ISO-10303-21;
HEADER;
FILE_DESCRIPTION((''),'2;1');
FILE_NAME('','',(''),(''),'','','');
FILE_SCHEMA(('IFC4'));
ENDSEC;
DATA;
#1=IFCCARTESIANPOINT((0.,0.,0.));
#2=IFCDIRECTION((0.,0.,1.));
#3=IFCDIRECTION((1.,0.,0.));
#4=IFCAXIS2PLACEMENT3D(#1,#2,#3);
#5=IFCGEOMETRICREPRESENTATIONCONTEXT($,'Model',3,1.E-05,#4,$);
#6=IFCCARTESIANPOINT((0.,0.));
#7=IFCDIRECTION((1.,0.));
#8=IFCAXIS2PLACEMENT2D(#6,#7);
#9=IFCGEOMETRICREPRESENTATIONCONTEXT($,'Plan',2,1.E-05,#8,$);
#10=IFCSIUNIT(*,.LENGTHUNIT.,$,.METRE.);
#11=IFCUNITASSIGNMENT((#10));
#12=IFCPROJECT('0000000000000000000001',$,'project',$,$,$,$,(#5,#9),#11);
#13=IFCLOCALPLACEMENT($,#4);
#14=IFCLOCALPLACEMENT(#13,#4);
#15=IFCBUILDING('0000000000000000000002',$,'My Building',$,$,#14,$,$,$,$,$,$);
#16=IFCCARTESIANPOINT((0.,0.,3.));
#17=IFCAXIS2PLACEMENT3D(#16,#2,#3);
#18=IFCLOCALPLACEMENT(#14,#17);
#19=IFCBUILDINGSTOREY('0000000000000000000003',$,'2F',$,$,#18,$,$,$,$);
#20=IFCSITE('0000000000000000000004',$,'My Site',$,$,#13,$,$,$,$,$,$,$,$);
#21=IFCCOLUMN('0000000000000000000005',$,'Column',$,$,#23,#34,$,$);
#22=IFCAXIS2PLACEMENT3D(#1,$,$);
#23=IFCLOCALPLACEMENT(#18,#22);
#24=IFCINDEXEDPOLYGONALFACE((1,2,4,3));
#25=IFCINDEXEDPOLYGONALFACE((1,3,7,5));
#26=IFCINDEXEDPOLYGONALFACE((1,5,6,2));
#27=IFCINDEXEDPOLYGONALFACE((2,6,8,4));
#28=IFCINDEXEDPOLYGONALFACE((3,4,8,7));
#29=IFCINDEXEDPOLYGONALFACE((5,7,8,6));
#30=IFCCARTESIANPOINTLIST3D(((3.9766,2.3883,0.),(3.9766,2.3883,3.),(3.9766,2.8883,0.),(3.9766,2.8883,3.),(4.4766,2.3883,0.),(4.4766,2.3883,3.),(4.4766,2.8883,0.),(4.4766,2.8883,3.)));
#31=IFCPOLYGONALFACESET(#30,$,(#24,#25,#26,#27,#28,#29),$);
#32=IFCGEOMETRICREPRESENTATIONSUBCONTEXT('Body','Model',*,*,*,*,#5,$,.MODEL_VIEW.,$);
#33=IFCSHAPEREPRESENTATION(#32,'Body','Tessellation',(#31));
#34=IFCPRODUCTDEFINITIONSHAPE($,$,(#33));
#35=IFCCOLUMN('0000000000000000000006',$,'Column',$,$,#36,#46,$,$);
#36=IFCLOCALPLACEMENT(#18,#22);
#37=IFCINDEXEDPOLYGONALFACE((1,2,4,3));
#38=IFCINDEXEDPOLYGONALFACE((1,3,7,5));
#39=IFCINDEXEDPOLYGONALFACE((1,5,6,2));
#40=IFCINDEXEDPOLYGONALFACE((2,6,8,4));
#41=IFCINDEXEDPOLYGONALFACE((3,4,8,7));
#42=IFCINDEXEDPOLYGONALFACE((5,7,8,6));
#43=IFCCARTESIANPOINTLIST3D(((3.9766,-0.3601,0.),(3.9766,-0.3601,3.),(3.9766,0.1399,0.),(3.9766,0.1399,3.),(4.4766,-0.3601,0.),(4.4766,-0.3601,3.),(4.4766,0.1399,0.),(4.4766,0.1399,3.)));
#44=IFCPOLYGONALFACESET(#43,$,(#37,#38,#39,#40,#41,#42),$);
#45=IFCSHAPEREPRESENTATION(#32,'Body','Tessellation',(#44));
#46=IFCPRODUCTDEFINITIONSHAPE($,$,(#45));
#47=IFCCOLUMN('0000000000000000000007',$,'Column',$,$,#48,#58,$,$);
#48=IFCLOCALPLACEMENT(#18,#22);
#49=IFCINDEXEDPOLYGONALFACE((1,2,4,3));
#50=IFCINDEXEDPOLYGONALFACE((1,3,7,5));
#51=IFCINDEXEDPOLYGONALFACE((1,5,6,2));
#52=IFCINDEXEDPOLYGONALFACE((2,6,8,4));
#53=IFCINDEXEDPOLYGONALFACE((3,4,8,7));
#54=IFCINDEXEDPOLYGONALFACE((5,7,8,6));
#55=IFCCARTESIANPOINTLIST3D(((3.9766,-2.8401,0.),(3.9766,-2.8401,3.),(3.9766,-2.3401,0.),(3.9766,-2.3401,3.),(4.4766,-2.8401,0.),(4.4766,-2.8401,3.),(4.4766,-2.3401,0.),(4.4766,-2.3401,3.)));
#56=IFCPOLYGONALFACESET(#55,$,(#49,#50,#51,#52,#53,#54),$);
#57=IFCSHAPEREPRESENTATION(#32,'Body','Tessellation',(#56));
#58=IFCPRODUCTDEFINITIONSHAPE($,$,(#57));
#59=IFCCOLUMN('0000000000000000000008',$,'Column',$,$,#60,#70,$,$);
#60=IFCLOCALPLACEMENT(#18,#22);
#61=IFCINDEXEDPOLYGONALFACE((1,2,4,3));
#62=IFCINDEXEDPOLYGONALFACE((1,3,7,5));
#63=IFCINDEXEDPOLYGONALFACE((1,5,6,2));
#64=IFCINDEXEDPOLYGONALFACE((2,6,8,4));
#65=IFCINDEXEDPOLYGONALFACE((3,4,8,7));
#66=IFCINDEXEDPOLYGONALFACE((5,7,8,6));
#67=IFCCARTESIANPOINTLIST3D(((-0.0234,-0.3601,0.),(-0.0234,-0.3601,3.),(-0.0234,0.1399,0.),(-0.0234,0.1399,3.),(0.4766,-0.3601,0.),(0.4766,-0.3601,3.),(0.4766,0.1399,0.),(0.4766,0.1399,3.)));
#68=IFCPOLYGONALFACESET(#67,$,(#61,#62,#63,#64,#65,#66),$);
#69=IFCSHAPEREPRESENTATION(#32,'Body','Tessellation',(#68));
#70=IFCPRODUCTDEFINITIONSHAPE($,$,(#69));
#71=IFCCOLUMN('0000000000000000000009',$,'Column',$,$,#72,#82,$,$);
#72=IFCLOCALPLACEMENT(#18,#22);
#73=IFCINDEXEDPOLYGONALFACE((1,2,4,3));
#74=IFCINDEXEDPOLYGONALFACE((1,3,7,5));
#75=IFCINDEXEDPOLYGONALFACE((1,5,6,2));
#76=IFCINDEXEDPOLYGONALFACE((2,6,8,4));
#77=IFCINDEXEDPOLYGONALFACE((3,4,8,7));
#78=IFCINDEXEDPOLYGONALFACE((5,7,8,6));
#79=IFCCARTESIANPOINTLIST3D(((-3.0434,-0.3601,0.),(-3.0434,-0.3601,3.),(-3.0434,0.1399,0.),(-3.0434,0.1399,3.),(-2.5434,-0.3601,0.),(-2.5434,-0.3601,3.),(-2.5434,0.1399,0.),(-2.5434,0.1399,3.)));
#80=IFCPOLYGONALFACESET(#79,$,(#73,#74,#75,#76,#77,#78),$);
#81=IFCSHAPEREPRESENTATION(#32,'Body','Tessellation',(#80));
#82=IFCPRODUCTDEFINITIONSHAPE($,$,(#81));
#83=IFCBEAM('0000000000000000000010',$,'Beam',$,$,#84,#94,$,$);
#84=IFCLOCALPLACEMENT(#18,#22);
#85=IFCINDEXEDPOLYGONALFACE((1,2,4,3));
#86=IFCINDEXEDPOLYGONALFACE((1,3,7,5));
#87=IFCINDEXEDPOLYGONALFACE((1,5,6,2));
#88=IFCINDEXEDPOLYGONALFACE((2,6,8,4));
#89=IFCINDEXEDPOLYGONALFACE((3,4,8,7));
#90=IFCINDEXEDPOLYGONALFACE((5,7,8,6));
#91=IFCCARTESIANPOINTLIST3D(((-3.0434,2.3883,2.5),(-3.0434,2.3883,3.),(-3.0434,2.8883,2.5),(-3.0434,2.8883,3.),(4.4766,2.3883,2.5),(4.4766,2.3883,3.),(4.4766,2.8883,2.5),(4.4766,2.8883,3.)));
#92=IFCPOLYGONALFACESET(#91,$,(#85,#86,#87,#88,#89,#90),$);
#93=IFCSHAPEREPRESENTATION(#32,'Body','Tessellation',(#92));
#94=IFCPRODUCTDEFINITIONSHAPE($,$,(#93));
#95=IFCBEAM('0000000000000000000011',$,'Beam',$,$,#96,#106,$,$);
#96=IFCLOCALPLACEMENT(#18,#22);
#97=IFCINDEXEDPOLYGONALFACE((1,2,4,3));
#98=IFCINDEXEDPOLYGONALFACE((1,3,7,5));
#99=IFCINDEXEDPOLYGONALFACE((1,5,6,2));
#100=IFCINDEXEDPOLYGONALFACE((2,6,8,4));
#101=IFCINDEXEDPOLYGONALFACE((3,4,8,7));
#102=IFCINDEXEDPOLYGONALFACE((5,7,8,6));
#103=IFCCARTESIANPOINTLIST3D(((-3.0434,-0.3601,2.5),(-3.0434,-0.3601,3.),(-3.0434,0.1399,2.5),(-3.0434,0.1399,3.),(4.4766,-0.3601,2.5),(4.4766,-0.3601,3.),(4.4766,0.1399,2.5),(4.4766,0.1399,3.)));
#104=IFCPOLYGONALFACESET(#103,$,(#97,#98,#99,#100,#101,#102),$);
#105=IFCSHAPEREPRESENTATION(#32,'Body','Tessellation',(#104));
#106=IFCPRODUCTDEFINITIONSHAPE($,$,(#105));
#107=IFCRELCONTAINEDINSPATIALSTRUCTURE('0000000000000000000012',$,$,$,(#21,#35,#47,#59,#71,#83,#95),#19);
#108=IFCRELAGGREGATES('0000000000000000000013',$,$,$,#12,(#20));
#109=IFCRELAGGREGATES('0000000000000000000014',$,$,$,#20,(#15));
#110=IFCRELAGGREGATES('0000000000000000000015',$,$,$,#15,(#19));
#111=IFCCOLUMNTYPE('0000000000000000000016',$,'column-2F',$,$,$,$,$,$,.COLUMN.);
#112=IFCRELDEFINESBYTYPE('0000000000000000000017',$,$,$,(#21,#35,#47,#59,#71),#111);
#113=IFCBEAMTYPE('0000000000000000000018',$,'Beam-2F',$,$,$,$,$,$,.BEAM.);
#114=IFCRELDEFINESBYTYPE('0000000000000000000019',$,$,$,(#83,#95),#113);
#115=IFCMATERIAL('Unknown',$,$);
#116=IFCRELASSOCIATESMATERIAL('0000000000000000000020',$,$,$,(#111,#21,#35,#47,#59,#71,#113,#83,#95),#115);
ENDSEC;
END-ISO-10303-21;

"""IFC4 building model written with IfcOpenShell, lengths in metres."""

from ifc_helpers import new_model, si_unit, frame, origin_with_axes, origin_2d_with_axis, place, context, subcontext, project, spatial, rectangle, extrude, material, material_profile, profile_set, profile_usage, type_object, element, save


model = new_model("IFC4")

# Units and contexts
model_context = context("Model", 3, precision=1e-05, world=origin_with_axes())
plan_context = context("Plan", 2, precision=1e-05, world=origin_2d_with_axis())
body_context_1 = subcontext(model_context, "Body", "Model", "MODEL_VIEW")
ifc_project = project(units=[si_unit("LENGTHUNIT", "METRE")], contexts=[model_context, plan_context])

# Site, building, storey
site_placement = place(None, origin_with_axes())
site = spatial("IfcSite", under=ifc_project, at=site_placement, Name="My Site")
building_placement = place(site_placement, origin_with_axes())
building = spatial("IfcBuilding", under=site, at=building_placement, Name="My Building")
storey_placement = place(building_placement, frame((0.0, 0.0, 3.0), z_axis=(0.0, 0.0, 1.0), x_axis=(1.0, 0.0, 0.0)))
storey = spatial("IfcBuildingStorey", under=building, at=storey_placement, Name="2F")

# Columns
ifc_material = material(Name="Unknown")
ifc_material_profile_1 = material_profile(ifc_material, rectangle(XDim=0.5, YDim=0.5))
ifc_profile_set_1 = profile_set([ifc_material_profile_1])
ifc_profile_usage_1 = profile_usage(ifc_profile_set_1, cardinal=7)
column_type = type_object("IfcColumnType", Name="column-2F", PredefinedType="COLUMN", material=ifc_profile_set_1)
column_1_placement = place(storey_placement, frame((4.4766, 2.8883, 0.0), z_axis=(0.0, 0.0, 1.0), x_axis=(1.0, 0.0, 0.0)))
element("IfcColumn", 1, at=column_1_placement, inside=storey, type_object=column_type, material=ifc_profile_usage_1, Name="Column", context=body_context_1, shape_type="SweptSolid", body=[
    extrude(rectangle(XDim=0.5, YDim=0.5), frame((-0.25, -0.25, 0.0), z_axis=(0.0, 0.0, 1.0), x_axis=(1.0, 0.0, 0.0)), (0.0, 0.0, 1.0), 3.0),
])
ifc_profile_usage_2 = profile_usage(ifc_profile_set_1, cardinal=7)
column_2_placement = place(storey_placement, frame((4.4766, 0.1399, 0.0), z_axis=(0.0, 0.0, 1.0), x_axis=(1.0, 0.0, 0.0)))
element("IfcColumn", 2, at=column_2_placement, inside=storey, type_object=column_type, material=ifc_profile_usage_2, Name="Column", context=body_context_1, shape_type="SweptSolid", body=[
    extrude(rectangle(XDim=0.5, YDim=0.5), frame((-0.25, -0.25, 0.0), z_axis=(0.0, 0.0, 1.0), x_axis=(1.0, 0.0, 0.0)), (0.0, 0.0, 1.0), 3.0),
])
ifc_profile_usage_3 = profile_usage(ifc_profile_set_1, cardinal=7)
column_3_placement = place(storey_placement, frame((4.4766, -2.3401, 0.0), z_axis=(0.0, 0.0, 1.0), x_axis=(1.0, 0.0, 0.0)))
element("IfcColumn", 3, at=column_3_placement, inside=storey, type_object=column_type, material=ifc_profile_usage_3, Name="Column", context=body_context_1, shape_type="SweptSolid", body=[
    extrude(rectangle(XDim=0.5, YDim=0.5), frame((-0.25, -0.25, 0.0), z_axis=(0.0, 0.0, 1.0), x_axis=(1.0, 0.0, 0.0)), (0.0, 0.0, 1.0), 3.0),
])
ifc_profile_usage_4 = profile_usage(ifc_profile_set_1, cardinal=7)
column_4_placement = place(storey_placement, frame((0.4766, 0.1399, 0.0), z_axis=(0.0, 0.0, 1.0), x_axis=(1.0, 0.0, 0.0)))
element("IfcColumn", 4, at=column_4_placement, inside=storey, type_object=column_type, material=ifc_profile_usage_4, Name="Column", context=body_context_1, shape_type="SweptSolid", body=[
    extrude(rectangle(XDim=0.5, YDim=0.5), frame((-0.25, -0.25, 0.0), z_axis=(0.0, 0.0, 1.0), x_axis=(1.0, 0.0, 0.0)), (0.0, 0.0, 1.0), 3.0),
])
ifc_profile_usage_5 = profile_usage(ifc_profile_set_1, cardinal=7)
column_5_placement = place(storey_placement, frame((-2.5434, 0.1399, 0.0), z_axis=(0.0, 0.0, 1.0), x_axis=(1.0, 0.0, 0.0)))
element("IfcColumn", 5, at=column_5_placement, inside=storey, type_object=column_type, material=ifc_profile_usage_5, Name="Column", context=body_context_1, shape_type="SweptSolid", body=[
    extrude(rectangle(XDim=0.5, YDim=0.5), frame((-0.25, -0.25, 0.0), z_axis=(0.0, 0.0, 1.0), x_axis=(1.0, 0.0, 0.0)), (0.0, 0.0, 1.0), 3.0),
])

# Beams
ifc_material_profile_2 = material_profile(ifc_material, rectangle(XDim=0.5, YDim=0.5))
ifc_profile_set_2 = profile_set([ifc_material_profile_2])
ifc_profile_usage_6 = profile_usage(ifc_profile_set_2, cardinal=7)
beam_type = type_object("IfcBeamType", Name="Beam-2F", PredefinedType="BEAM", material=ifc_profile_set_2)
beam_1_placement = place(storey_placement, frame((4.4766, 2.3883, 3.0), z_axis=(-1.0, 0.0, 0.0), x_axis=(0.0, -1.0, 0.0)))
element("IfcBeam", 6, at=beam_1_placement, inside=storey, type_object=beam_type, material=ifc_profile_usage_6, Name="Beam", context=body_context_1, shape_type="SweptSolid", body=[
    extrude(rectangle(XDim=0.5, YDim=0.5), frame((-0.25, -0.25, 0.0), z_axis=(0.0, 0.0, 1.0), x_axis=(1.0, 0.0, 0.0)), (0.0, 0.0, 1.0), 7.52),
])
ifc_profile_usage_7 = profile_usage(ifc_profile_set_2, cardinal=7)
beam_2_placement = place(storey_placement, frame((4.4766, -0.3601, 3.0), z_axis=(-1.0, 0.0, 0.0), x_axis=(0.0, -1.0, 0.0)))
element("IfcBeam", 7, at=beam_2_placement, inside=storey, type_object=beam_type, material=ifc_profile_usage_7, Name="Beam", context=body_context_1, shape_type="SweptSolid", body=[
    extrude(rectangle(XDim=0.5, YDim=0.5), frame((-0.25, -0.25, 0.0), z_axis=(0.0, 0.0, 1.0), x_axis=(1.0, 0.0, 0.0)), (0.0, 0.0, 1.0), 7.52),
])

save(model, "model.ifc")
